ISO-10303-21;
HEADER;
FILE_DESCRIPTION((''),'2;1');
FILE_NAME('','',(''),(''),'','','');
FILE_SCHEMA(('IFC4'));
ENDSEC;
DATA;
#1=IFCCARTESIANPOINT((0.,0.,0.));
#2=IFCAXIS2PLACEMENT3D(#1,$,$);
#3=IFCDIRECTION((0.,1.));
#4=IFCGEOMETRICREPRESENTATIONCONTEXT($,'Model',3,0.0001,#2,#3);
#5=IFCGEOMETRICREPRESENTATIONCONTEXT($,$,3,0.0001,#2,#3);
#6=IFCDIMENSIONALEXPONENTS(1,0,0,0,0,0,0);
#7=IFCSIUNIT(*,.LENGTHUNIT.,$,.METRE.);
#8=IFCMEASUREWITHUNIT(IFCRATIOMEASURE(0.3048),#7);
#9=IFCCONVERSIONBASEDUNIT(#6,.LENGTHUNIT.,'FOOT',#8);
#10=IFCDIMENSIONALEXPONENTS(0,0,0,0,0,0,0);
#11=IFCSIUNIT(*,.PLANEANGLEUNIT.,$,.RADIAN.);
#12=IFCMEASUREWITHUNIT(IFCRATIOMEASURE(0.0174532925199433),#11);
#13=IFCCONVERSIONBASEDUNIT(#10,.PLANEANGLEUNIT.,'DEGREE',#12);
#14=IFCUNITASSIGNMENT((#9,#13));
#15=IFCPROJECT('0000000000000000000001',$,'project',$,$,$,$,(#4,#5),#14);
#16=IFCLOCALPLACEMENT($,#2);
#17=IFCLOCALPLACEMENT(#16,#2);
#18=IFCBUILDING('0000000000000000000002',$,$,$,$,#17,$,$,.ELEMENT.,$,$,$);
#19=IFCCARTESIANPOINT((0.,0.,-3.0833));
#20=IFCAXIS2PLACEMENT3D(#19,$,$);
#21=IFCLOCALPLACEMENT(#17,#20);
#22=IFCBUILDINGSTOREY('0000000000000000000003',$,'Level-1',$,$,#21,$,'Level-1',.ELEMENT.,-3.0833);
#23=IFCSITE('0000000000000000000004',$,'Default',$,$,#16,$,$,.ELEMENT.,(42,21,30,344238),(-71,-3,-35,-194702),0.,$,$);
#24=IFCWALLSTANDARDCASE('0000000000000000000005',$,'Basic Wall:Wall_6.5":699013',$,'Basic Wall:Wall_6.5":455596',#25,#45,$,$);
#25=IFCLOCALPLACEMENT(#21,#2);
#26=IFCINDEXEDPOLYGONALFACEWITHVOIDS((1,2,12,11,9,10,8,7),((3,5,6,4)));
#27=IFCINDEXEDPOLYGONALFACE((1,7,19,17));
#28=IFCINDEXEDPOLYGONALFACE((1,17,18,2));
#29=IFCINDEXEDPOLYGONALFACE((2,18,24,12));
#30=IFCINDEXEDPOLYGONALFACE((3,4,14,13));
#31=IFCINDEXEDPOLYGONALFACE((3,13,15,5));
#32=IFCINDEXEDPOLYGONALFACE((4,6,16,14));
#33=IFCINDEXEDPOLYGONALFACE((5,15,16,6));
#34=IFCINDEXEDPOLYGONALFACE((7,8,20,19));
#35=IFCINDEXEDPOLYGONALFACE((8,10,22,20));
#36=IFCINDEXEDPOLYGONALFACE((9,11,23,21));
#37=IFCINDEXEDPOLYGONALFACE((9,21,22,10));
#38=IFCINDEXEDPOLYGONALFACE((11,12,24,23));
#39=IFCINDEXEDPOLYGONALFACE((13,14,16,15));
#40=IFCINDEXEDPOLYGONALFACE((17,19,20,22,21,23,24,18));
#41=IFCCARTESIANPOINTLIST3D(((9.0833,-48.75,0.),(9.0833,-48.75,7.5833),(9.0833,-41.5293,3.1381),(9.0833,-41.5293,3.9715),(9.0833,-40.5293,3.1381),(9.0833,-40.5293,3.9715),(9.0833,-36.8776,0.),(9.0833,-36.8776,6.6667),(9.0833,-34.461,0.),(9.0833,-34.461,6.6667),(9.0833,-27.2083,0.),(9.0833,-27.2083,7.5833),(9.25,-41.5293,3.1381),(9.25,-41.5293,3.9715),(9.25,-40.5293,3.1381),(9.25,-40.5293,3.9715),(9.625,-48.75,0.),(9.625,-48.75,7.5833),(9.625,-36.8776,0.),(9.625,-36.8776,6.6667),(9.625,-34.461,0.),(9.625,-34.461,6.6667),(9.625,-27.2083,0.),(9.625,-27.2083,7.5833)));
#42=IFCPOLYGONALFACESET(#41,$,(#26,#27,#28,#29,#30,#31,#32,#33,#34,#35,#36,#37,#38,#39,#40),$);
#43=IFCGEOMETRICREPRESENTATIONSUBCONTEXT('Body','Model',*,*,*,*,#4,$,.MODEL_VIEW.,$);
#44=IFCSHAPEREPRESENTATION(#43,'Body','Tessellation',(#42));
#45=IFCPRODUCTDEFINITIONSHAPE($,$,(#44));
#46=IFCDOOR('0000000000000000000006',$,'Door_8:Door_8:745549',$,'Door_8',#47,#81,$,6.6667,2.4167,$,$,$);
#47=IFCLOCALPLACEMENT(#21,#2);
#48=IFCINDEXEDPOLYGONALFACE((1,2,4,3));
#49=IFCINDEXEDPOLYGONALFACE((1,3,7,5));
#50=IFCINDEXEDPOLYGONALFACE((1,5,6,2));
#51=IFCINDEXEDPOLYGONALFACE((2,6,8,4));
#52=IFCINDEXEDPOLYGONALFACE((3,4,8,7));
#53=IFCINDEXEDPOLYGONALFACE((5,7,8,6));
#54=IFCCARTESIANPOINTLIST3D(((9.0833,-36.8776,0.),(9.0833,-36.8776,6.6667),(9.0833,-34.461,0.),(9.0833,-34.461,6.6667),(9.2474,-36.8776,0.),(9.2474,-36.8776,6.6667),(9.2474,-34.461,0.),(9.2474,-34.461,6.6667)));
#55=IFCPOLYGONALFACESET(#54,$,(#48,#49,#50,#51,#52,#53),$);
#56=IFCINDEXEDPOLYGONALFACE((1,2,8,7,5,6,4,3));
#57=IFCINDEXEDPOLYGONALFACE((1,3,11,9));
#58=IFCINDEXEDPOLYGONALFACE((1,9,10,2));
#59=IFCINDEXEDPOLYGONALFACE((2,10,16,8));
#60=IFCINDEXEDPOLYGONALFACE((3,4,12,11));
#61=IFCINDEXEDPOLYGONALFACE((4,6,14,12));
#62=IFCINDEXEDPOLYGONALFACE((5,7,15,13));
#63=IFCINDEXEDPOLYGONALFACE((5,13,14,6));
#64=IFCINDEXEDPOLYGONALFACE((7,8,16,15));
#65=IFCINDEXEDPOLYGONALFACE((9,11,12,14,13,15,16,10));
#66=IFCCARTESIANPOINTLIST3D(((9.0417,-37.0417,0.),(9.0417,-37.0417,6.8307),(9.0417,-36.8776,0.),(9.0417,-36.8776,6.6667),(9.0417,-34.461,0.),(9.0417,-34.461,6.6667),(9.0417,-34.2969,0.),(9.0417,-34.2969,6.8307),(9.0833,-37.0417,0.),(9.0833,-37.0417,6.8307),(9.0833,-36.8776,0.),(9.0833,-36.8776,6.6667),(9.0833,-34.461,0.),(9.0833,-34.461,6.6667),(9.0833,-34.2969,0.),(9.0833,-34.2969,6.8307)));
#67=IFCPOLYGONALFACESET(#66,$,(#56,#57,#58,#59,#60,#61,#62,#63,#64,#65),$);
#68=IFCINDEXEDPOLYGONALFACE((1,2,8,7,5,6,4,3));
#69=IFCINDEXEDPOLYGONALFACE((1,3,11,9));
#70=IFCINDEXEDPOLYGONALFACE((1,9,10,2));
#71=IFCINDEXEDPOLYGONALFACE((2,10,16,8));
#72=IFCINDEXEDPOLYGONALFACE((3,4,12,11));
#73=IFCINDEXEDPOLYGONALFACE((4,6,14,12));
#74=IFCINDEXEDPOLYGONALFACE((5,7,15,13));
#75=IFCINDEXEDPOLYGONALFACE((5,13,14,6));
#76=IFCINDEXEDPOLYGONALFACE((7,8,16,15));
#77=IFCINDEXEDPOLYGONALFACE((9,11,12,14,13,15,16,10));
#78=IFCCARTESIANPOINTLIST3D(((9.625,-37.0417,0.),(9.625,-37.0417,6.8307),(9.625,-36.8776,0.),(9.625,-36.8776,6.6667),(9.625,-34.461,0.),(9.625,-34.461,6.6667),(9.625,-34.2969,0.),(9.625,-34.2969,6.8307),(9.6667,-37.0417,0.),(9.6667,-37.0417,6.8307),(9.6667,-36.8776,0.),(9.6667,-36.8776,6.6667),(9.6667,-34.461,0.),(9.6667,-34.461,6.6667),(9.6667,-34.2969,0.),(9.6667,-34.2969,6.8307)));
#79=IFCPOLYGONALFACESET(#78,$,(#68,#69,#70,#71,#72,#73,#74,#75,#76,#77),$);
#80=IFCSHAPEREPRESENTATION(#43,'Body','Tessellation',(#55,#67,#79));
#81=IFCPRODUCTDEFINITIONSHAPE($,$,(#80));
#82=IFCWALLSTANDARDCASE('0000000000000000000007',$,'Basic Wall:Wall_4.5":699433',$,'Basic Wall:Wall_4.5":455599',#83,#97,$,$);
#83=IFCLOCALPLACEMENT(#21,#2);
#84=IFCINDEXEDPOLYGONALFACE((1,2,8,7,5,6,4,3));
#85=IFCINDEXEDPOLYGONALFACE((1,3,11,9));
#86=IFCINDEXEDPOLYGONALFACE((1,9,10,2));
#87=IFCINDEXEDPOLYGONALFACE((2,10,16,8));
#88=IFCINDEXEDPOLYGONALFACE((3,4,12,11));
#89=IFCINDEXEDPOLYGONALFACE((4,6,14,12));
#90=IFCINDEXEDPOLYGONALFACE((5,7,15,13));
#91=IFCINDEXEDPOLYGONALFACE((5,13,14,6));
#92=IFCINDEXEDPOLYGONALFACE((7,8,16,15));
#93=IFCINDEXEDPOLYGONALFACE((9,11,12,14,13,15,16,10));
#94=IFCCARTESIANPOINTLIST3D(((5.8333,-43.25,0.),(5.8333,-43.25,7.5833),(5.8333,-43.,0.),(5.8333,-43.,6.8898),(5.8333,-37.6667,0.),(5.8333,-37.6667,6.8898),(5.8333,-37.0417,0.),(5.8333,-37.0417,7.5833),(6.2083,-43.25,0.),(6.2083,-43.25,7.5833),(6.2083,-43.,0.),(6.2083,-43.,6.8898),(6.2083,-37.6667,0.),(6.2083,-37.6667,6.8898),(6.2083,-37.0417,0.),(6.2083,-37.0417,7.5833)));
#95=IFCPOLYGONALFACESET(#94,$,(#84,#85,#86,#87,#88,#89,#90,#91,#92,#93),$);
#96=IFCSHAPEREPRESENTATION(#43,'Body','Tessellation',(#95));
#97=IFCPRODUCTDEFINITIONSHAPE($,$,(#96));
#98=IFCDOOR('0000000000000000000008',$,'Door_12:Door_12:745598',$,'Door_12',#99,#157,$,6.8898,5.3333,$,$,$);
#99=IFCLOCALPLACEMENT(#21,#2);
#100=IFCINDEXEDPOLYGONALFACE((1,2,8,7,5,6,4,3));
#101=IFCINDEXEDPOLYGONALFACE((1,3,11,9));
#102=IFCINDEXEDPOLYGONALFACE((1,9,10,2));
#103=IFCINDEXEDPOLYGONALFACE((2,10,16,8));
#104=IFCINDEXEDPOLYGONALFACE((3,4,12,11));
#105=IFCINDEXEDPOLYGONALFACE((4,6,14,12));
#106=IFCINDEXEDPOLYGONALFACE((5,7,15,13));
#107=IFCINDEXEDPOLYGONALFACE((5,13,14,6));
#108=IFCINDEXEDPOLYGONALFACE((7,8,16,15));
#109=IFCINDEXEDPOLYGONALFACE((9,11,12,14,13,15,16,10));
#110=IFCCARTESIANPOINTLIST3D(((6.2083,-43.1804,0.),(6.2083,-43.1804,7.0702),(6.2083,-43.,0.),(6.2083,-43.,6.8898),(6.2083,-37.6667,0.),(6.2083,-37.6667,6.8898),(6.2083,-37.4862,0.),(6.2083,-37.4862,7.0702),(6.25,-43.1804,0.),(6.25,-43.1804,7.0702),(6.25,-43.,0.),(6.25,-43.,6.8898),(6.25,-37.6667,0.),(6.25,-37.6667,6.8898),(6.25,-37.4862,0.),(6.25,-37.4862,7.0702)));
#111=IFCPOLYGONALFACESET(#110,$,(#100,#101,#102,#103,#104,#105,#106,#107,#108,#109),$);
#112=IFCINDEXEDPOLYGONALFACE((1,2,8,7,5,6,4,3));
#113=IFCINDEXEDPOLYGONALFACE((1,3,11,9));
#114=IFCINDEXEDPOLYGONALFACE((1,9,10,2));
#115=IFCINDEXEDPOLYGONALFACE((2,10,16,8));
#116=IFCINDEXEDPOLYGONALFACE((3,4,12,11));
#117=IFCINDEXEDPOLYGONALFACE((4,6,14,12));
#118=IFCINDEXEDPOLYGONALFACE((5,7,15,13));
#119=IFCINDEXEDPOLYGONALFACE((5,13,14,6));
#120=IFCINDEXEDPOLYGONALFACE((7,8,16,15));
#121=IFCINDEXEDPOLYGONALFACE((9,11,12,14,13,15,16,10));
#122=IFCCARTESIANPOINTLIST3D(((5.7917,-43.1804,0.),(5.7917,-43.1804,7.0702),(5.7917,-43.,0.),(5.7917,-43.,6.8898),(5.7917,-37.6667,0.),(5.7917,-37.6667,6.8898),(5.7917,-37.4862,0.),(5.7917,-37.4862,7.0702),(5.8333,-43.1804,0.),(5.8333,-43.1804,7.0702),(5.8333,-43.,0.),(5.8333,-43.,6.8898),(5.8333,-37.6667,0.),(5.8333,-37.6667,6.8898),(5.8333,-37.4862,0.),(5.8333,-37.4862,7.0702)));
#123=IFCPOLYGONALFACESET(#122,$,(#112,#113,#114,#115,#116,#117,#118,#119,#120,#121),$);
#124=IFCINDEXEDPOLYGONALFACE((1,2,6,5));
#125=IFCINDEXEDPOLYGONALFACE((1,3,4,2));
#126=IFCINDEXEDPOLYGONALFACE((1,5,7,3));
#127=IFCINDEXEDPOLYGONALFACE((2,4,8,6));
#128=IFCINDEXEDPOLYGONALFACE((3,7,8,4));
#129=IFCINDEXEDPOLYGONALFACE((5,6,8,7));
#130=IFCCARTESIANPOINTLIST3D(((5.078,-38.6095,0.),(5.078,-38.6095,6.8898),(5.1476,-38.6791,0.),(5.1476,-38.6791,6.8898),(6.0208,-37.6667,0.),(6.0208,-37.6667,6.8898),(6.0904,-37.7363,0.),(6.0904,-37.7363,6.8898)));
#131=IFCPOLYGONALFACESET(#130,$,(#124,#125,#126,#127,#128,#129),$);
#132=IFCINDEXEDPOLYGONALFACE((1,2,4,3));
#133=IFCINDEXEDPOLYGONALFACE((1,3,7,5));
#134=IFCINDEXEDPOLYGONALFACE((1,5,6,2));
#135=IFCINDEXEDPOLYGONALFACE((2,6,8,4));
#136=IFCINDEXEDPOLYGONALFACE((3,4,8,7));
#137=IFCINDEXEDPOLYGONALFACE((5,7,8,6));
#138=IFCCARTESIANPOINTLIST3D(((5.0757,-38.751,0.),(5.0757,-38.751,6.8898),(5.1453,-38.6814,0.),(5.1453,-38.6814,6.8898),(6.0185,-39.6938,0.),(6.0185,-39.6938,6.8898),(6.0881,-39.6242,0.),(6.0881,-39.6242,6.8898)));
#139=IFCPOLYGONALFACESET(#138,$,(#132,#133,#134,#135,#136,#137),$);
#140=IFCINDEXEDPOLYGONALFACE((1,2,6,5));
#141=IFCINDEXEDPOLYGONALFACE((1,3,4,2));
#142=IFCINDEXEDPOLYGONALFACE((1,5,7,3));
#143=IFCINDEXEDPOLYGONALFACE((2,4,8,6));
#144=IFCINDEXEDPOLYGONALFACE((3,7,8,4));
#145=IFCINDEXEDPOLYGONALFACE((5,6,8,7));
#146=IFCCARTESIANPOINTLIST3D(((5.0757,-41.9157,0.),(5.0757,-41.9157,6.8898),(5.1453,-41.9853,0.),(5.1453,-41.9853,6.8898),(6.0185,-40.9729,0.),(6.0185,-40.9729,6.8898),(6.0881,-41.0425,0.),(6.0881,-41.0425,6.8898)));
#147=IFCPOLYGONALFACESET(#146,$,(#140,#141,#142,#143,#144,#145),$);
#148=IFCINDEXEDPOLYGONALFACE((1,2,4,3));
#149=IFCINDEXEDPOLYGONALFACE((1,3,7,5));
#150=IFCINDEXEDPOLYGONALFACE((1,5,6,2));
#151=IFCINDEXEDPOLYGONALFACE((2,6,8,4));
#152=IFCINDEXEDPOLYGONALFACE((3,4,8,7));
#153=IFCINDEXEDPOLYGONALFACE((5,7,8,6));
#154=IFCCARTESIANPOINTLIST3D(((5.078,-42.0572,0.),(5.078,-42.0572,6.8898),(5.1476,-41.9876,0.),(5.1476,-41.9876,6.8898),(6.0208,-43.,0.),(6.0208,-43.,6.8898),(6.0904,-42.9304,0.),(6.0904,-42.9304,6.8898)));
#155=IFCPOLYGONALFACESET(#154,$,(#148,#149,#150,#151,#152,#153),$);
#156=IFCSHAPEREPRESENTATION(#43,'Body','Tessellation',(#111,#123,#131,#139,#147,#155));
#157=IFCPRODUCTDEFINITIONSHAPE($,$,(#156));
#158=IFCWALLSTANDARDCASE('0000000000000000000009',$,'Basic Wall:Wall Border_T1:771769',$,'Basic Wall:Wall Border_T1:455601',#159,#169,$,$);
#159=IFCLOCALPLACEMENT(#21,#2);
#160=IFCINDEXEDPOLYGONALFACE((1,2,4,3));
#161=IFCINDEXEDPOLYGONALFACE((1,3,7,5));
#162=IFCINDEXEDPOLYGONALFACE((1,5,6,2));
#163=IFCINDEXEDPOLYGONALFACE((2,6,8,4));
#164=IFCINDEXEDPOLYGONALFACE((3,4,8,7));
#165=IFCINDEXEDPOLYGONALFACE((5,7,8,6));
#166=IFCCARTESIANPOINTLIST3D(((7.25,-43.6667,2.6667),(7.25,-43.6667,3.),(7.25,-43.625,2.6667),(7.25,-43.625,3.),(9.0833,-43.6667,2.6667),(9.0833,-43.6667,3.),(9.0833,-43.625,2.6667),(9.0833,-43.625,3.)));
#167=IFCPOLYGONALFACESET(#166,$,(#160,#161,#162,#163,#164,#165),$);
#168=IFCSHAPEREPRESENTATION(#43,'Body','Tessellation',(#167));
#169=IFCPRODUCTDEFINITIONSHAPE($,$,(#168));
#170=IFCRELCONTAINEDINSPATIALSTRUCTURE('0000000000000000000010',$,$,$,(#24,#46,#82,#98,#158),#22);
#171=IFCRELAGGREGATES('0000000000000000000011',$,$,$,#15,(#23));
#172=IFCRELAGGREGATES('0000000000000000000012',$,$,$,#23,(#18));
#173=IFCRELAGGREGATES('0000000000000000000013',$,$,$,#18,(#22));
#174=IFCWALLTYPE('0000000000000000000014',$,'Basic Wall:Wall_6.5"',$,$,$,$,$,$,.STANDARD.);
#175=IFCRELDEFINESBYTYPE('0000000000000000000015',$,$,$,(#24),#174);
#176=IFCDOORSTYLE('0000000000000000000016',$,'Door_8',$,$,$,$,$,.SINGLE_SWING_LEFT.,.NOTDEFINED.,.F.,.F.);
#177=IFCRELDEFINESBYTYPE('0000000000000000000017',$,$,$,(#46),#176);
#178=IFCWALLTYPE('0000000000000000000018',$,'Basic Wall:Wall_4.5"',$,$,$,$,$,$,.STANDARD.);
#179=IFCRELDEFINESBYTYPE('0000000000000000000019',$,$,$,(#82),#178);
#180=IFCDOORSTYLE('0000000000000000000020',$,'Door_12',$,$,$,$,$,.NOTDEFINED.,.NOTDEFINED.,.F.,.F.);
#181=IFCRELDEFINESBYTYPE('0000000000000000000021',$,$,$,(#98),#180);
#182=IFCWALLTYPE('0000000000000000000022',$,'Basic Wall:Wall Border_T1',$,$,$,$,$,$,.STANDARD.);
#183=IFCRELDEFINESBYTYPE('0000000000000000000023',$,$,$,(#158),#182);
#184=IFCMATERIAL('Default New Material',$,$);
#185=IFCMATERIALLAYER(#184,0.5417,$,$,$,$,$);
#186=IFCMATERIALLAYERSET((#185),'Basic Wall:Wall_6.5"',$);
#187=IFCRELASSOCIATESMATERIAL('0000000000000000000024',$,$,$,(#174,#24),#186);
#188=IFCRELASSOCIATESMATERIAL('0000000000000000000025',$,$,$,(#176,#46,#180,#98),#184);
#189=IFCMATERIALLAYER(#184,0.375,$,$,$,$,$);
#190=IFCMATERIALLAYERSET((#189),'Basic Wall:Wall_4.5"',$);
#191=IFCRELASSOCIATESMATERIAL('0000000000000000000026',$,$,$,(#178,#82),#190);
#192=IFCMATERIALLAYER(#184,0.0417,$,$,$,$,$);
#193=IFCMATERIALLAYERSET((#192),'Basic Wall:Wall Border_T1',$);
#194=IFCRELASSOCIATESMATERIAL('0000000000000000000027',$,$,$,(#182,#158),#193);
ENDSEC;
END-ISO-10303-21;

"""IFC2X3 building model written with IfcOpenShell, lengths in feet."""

from ifc_helpers import new_model, entity, si_unit, converted_unit, direction, frame, frame_2d, origin, origin_2d_with_axis, place, context, subcontext, project, spatial, polyline, rectangle, outline, extrude, source, transform, mapped, material, layer, layer_set, layer_usage, type_object, type_shapes, element, fill, save


model = new_model("IFC2X3")

# Units and contexts
model_context = context("Model", 3, precision=0.0001, world=origin(), true_north=direction((0.0, 1.0)))
context_of_model = context(None, 3, precision=0.0001, world=origin(), true_north=direction((0.0, 1.0)))
body_context = subcontext(model_context, "Body", "Model", "MODEL_VIEW")
ifc_project = project(units=[converted_unit("LENGTHUNIT", "FOOT", entity("IfcRatioMeasure", 0.3048), si_unit("LENGTHUNIT", "METRE"), dimensions=[1, 0, 0, 0, 0, 0, 0]), converted_unit("PLANEANGLEUNIT", "DEGREE", entity("IfcRatioMeasure", 0.0174532925199433), si_unit("PLANEANGLEUNIT", "RADIAN"), dimensions=[0, 0, 0, 0, 0, 0, 0])], contexts=[model_context, context_of_model])

# Site, building, storey
site_placement = place(None, origin())
site = spatial("IfcSite", under=ifc_project, at=site_placement, Name="Default", CompositionType="ELEMENT", RefLatitude=(42, 21, 30, 344238), RefLongitude=(-71, -3, -35, -194702), RefElevation=0.0)
building_placement = place(site_placement, origin())
building = spatial("IfcBuilding", under=site, at=building_placement, CompositionType="ELEMENT")
storey_placement = place(building_placement, frame((0.0, 0.0, -3.0833)))
storey = spatial("IfcBuildingStorey", under=building, at=storey_placement, Name="Level-1", LongName="Level-1", CompositionType="ELEMENT", Elevation=-3.0833)

# Wall, openings, door
ifc_material = material(Name="Default New Material")
ifc_layer_1 = layer(ifc_material, 0.5417)
ifc_layer_set_1 = layer_set([ifc_layer_1], Name="Basic Wall:Wall_6.5\"")
ifc_layer_usage_1 = layer_usage(ifc_layer_set_1, "AXIS2", "NEGATIVE", 0.2708)
wall_type_1 = type_object("IfcWallType", Name="Basic Wall:Wall_6.5\"", PredefinedType="STANDARD", material=ifc_layer_set_1)
wall_1_placement = place(storey_placement, frame((9.3542, -48.75, 0.0), z_axis=(0.0, 0.0, 1.0), x_axis=(0.0, 1.0, 0.0)))
wall_1 = element("IfcWallStandardCase", 1, at=wall_1_placement, inside=storey, type_object=wall_type_1, material=ifc_layer_usage_1, Name="Basic Wall:Wall_6.5\":699013", ObjectType="Basic Wall:Wall_6.5\":455596", context=body_context, shape_type="SweptSolid", body=[
    extrude(rectangle(XDim=21.5417, YDim=0.5417, at=frame_2d((10.7708, 0.0), x_axis=(-1.0, 0.0))), origin(), (0.0, 0.0, 1.0), 7.5833),
])
opening_1_placement = place(wall_1_placement, frame((7.2207, 0.2708, 3.1381)))
element("IfcOpeningElement", 2, at=opening_1_placement, cuts=wall_1, ObjectType="Recess", context=body_context, shape_type="SweptSolid", body=[
    extrude(rectangle(XDim=0.8333, YDim=1.0, at=origin_2d_with_axis()), frame((0.5, -0.1667, 0.4167), z_axis=(0.0, 1.0, 0.0), x_axis=(0.0, 0.0, -1.0)), (0.0, 0.0, 1.0), 0.1667),
])
opening_2_placement = place(wall_1_placement, frame((11.8724, -0.2708, 0.0)))
opening_2 = element("IfcOpeningElement", 3, at=opening_2_placement, cuts=wall_1, ObjectType="Opening", context=body_context, shape_type="SweptSolid", body=[
    extrude(rectangle(XDim=2.4167, YDim=6.6667, at=frame_2d((3.3333, 1.2083), x_axis=(0.0, -1.0))), frame((0.0, 0.0, 0.0), z_axis=(0.0, 1.0, 0.0), x_axis=(0.0, 0.0, 1.0)), (0.0, 0.0, 1.0), 0.5417),
])
door_style_1 = type_object("IfcDoorStyle", Name="Door_8", ConstructionType="NOTDEFINED", OperationType="SINGLE_SWING_LEFT", ParameterTakesPrecedence=False, Sizeable=False, material=ifc_material)
shared_shape_1 = source(origin(), body_context, "Body", "SweptSolid", [
    extrude(rectangle(XDim=2.4167, YDim=0.164, at=origin_2d_with_axis()), frame((1.2083, 0.4596, 0.0)), (0.0, 0.0, 1.0), 6.6667),
    extrude(outline(polyline([(-1.3724, -3.4564), (1.3724, -3.4564), (1.3724, 3.3743), (1.2083, 3.3743), (1.2083, -3.2923), (-1.2083, -3.2923), (-1.2083, 3.3743), (-1.3724, 3.3743), (-1.3724, -3.4564)])), frame((1.2083, 0.5833, 3.3743), z_axis=(0.0, -1.0, 0.0), x_axis=(-1.0, 0.0, 0.0)), (0.0, 0.0, 1.0), 0.0417),
    extrude(outline(polyline([(-3.4564, -1.3724), (3.3743, -1.3724), (3.3743, -1.2083), (-3.2923, -1.2083), (-3.2923, 1.2083), (3.3743, 1.2083), (3.3743, 1.3724), (-3.4564, 1.3724), (-3.4564, -1.3724)])), frame((1.2083, 0.0, 3.3743), z_axis=(0.0, -1.0, 0.0), x_axis=(0.0, 0.0, -1.0)), (0.0, 0.0, 1.0), 0.0417),
])
type_shapes(door_style_1, [shared_shape_1])
door_1_placement = place(opening_2_placement, origin())
door_1 = element("IfcDoor", 4, at=door_1_placement, inside=storey, type_object=door_style_1, material=ifc_material, Name="Door_8:Door_8:745549", ObjectType="Door_8", OverallHeight=6.6667, OverallWidth=2.4167, context=body_context, shape_type="MappedRepresentation", body=[
    mapped(shared_shape_1, transform((0.0, 0.0, 0.0), scale=1.0)),
])
fill(opening_2, door_1)

# Wall, opening, door
ifc_layer_2 = layer(ifc_material, 0.375)
ifc_layer_set_2 = layer_set([ifc_layer_2], Name="Basic Wall:Wall_4.5\"")
wall_type_2 = type_object("IfcWallType", Name="Basic Wall:Wall_4.5\"", PredefinedType="STANDARD", material=ifc_layer_set_2)
ifc_layer_usage_2 = layer_usage(ifc_layer_set_2, "AXIS2", "NEGATIVE", 0.1875)
wall_2_placement = place(storey_placement, frame((6.0208, -43.25, 0.0), z_axis=(0.0, 0.0, 1.0), x_axis=(0.0, 1.0, 0.0)))
wall_2 = element("IfcWallStandardCase", 5, at=wall_2_placement, inside=storey, type_object=wall_type_2, material=ifc_layer_usage_2, Name="Basic Wall:Wall_4.5\":699433", ObjectType="Basic Wall:Wall_4.5\":455599", context=body_context, shape_type="SweptSolid", body=[
    extrude(rectangle(XDim=6.2083, YDim=0.375, at=frame_2d((3.1042, 0.0), x_axis=(-1.0, 0.0))), origin(), (0.0, 0.0, 1.0), 7.5833),
])
opening_3_placement = place(wall_2_placement, frame((5.5833, 0.1875, 0.0)))
opening_3 = element("IfcOpeningElement", 6, at=opening_3_placement, cuts=wall_2, ObjectType="Opening", context=body_context, shape_type="SweptSolid", body=[
    extrude(rectangle(XDim=6.8898, YDim=5.3333, at=frame_2d((3.4449, 2.6667), x_axis=(1.0, 0.0))), frame((0.0, 0.0, 0.0), z_axis=(0.0, -1.0, 0.0), x_axis=(0.0, 0.0, 1.0)), (0.0, 0.0, 1.0), 0.375),
])
door_style_2 = type_object("IfcDoorStyle", Name="Door_12", ConstructionType="NOTDEFINED", OperationType="NOTDEFINED", ParameterTakesPrecedence=False, Sizeable=False, material=ifc_material)
shared_shape_2 = source(origin(), body_context, "Body", "SweptSolid", [
    extrude(outline(polyline([(-3.3998, 2.6667), (3.49, 2.6667), (3.49, 2.8471), (-3.5802, 2.8471), (-3.5802, -2.8471), (3.49, -2.8471), (3.49, -2.6667), (-3.3998, -2.6667), (-3.3998, 2.6667)])), frame((2.6667, 0.375, 3.49), z_axis=(0.0, 1.0, 0.0), x_axis=(0.0, 0.0, -1.0)), (0.0, 0.0, 1.0), 0.0417),
    extrude(outline(polyline([(-2.8471, -3.5802), (2.8471, -3.5802), (2.8471, 3.49), (2.6667, 3.49), (2.6667, -3.3998), (-2.6667, -3.3998), (-2.6667, 3.49), (-2.8471, 3.49), (-2.8471, -3.5802)])), frame((2.6667, -0.0417, 3.49), z_axis=(0.0, 1.0, 0.0), x_axis=(1.0, 0.0, 0.0)), (0.0, 0.0, 1.0), 0.0417),
    extrude(rectangle(XDim=0.0984, YDim=1.3333, at=frame_2d((0.0, 0.0), x_axis=(1.0, 0.0))), frame((0.5062, -0.2491, 0.0), z_axis=(0.0, 0.0, 1.0), x_axis=(0.707107, 0.707107, 0.0)), (0.0, 0.0, 1.0), 6.8898),
    extrude(rectangle(XDim=0.0984, YDim=1.3333, at=frame_2d((0.0, 0.0), x_axis=(1.0, 0.0))), frame((1.5209, -0.2514, 0.0), z_axis=(0.0, 0.0, 1.0), x_axis=(0.707107, -0.707107, 0.0)), (0.0, 0.0, 1.0), 6.8898),
    extrude(rectangle(XDim=1.3333, YDim=0.0984, at=frame_2d((0.0, 0.0), x_axis=(1.0, 0.0))), frame((3.8124, -0.2514, 0.0), z_axis=(0.0, 0.0, 1.0), x_axis=(-0.707107, 0.707107, 0.0)), (0.0, 0.0, 1.0), 6.8898),
    extrude(rectangle(XDim=1.3333, YDim=0.0984, at=frame_2d((0.0, 0.0), x_axis=(1.0, 0.0))), frame((4.8271, -0.2491, 0.0), z_axis=(0.0, 0.0, 1.0), x_axis=(0.707107, 0.707107, 0.0)), (0.0, 0.0, 1.0), 6.8898),
])
type_shapes(door_style_2, [shared_shape_2])
door_2_placement = place(opening_3_placement, frame((0.0, 0.0, 0.0), z_axis=(0.0, 0.0, 1.0), x_axis=(-1.0, 0.0, 0.0)))
door_2 = element("IfcDoor", 7, at=door_2_placement, inside=storey, type_object=door_style_2, material=ifc_material, Name="Door_12:Door_12:745598", ObjectType="Door_12", OverallHeight=6.8898, OverallWidth=5.3333, context=body_context, shape_type="MappedRepresentation", body=[
    mapped(shared_shape_2, transform((0.0, 0.0, 0.0), scale=1.0)),
])
fill(opening_3, door_2)

# Wall
ifc_layer_3 = layer(ifc_material, 0.0417)
ifc_layer_set_3 = layer_set([ifc_layer_3], Name="Basic Wall:Wall Border_T1")
ifc_layer_usage_3 = layer_usage(ifc_layer_set_3, "AXIS2", "NEGATIVE", 0.0208)
wall_type_3 = type_object("IfcWallType", Name="Basic Wall:Wall Border_T1", PredefinedType="STANDARD", material=ifc_layer_set_3)
wall_3_placement = place(storey_placement, frame((9.0833, -43.6458, 2.6667), z_axis=(0.0, 0.0, 1.0), x_axis=(-1.0, 0.0, 0.0)))
element("IfcWallStandardCase", 8, at=wall_3_placement, inside=storey, type_object=wall_type_3, material=ifc_layer_usage_3, Name="Basic Wall:Wall Border_T1:771769", ObjectType="Basic Wall:Wall Border_T1:455601", context=body_context, shape_type="SweptSolid", body=[
    extrude(rectangle(XDim=1.8333, YDim=0.0417, at=frame_2d((0.9167, 0.0), x_axis=(-1.0, 0.0))), origin(), (0.0, 0.0, 1.0), 0.3333),
])

save(model, "model.ifc")
